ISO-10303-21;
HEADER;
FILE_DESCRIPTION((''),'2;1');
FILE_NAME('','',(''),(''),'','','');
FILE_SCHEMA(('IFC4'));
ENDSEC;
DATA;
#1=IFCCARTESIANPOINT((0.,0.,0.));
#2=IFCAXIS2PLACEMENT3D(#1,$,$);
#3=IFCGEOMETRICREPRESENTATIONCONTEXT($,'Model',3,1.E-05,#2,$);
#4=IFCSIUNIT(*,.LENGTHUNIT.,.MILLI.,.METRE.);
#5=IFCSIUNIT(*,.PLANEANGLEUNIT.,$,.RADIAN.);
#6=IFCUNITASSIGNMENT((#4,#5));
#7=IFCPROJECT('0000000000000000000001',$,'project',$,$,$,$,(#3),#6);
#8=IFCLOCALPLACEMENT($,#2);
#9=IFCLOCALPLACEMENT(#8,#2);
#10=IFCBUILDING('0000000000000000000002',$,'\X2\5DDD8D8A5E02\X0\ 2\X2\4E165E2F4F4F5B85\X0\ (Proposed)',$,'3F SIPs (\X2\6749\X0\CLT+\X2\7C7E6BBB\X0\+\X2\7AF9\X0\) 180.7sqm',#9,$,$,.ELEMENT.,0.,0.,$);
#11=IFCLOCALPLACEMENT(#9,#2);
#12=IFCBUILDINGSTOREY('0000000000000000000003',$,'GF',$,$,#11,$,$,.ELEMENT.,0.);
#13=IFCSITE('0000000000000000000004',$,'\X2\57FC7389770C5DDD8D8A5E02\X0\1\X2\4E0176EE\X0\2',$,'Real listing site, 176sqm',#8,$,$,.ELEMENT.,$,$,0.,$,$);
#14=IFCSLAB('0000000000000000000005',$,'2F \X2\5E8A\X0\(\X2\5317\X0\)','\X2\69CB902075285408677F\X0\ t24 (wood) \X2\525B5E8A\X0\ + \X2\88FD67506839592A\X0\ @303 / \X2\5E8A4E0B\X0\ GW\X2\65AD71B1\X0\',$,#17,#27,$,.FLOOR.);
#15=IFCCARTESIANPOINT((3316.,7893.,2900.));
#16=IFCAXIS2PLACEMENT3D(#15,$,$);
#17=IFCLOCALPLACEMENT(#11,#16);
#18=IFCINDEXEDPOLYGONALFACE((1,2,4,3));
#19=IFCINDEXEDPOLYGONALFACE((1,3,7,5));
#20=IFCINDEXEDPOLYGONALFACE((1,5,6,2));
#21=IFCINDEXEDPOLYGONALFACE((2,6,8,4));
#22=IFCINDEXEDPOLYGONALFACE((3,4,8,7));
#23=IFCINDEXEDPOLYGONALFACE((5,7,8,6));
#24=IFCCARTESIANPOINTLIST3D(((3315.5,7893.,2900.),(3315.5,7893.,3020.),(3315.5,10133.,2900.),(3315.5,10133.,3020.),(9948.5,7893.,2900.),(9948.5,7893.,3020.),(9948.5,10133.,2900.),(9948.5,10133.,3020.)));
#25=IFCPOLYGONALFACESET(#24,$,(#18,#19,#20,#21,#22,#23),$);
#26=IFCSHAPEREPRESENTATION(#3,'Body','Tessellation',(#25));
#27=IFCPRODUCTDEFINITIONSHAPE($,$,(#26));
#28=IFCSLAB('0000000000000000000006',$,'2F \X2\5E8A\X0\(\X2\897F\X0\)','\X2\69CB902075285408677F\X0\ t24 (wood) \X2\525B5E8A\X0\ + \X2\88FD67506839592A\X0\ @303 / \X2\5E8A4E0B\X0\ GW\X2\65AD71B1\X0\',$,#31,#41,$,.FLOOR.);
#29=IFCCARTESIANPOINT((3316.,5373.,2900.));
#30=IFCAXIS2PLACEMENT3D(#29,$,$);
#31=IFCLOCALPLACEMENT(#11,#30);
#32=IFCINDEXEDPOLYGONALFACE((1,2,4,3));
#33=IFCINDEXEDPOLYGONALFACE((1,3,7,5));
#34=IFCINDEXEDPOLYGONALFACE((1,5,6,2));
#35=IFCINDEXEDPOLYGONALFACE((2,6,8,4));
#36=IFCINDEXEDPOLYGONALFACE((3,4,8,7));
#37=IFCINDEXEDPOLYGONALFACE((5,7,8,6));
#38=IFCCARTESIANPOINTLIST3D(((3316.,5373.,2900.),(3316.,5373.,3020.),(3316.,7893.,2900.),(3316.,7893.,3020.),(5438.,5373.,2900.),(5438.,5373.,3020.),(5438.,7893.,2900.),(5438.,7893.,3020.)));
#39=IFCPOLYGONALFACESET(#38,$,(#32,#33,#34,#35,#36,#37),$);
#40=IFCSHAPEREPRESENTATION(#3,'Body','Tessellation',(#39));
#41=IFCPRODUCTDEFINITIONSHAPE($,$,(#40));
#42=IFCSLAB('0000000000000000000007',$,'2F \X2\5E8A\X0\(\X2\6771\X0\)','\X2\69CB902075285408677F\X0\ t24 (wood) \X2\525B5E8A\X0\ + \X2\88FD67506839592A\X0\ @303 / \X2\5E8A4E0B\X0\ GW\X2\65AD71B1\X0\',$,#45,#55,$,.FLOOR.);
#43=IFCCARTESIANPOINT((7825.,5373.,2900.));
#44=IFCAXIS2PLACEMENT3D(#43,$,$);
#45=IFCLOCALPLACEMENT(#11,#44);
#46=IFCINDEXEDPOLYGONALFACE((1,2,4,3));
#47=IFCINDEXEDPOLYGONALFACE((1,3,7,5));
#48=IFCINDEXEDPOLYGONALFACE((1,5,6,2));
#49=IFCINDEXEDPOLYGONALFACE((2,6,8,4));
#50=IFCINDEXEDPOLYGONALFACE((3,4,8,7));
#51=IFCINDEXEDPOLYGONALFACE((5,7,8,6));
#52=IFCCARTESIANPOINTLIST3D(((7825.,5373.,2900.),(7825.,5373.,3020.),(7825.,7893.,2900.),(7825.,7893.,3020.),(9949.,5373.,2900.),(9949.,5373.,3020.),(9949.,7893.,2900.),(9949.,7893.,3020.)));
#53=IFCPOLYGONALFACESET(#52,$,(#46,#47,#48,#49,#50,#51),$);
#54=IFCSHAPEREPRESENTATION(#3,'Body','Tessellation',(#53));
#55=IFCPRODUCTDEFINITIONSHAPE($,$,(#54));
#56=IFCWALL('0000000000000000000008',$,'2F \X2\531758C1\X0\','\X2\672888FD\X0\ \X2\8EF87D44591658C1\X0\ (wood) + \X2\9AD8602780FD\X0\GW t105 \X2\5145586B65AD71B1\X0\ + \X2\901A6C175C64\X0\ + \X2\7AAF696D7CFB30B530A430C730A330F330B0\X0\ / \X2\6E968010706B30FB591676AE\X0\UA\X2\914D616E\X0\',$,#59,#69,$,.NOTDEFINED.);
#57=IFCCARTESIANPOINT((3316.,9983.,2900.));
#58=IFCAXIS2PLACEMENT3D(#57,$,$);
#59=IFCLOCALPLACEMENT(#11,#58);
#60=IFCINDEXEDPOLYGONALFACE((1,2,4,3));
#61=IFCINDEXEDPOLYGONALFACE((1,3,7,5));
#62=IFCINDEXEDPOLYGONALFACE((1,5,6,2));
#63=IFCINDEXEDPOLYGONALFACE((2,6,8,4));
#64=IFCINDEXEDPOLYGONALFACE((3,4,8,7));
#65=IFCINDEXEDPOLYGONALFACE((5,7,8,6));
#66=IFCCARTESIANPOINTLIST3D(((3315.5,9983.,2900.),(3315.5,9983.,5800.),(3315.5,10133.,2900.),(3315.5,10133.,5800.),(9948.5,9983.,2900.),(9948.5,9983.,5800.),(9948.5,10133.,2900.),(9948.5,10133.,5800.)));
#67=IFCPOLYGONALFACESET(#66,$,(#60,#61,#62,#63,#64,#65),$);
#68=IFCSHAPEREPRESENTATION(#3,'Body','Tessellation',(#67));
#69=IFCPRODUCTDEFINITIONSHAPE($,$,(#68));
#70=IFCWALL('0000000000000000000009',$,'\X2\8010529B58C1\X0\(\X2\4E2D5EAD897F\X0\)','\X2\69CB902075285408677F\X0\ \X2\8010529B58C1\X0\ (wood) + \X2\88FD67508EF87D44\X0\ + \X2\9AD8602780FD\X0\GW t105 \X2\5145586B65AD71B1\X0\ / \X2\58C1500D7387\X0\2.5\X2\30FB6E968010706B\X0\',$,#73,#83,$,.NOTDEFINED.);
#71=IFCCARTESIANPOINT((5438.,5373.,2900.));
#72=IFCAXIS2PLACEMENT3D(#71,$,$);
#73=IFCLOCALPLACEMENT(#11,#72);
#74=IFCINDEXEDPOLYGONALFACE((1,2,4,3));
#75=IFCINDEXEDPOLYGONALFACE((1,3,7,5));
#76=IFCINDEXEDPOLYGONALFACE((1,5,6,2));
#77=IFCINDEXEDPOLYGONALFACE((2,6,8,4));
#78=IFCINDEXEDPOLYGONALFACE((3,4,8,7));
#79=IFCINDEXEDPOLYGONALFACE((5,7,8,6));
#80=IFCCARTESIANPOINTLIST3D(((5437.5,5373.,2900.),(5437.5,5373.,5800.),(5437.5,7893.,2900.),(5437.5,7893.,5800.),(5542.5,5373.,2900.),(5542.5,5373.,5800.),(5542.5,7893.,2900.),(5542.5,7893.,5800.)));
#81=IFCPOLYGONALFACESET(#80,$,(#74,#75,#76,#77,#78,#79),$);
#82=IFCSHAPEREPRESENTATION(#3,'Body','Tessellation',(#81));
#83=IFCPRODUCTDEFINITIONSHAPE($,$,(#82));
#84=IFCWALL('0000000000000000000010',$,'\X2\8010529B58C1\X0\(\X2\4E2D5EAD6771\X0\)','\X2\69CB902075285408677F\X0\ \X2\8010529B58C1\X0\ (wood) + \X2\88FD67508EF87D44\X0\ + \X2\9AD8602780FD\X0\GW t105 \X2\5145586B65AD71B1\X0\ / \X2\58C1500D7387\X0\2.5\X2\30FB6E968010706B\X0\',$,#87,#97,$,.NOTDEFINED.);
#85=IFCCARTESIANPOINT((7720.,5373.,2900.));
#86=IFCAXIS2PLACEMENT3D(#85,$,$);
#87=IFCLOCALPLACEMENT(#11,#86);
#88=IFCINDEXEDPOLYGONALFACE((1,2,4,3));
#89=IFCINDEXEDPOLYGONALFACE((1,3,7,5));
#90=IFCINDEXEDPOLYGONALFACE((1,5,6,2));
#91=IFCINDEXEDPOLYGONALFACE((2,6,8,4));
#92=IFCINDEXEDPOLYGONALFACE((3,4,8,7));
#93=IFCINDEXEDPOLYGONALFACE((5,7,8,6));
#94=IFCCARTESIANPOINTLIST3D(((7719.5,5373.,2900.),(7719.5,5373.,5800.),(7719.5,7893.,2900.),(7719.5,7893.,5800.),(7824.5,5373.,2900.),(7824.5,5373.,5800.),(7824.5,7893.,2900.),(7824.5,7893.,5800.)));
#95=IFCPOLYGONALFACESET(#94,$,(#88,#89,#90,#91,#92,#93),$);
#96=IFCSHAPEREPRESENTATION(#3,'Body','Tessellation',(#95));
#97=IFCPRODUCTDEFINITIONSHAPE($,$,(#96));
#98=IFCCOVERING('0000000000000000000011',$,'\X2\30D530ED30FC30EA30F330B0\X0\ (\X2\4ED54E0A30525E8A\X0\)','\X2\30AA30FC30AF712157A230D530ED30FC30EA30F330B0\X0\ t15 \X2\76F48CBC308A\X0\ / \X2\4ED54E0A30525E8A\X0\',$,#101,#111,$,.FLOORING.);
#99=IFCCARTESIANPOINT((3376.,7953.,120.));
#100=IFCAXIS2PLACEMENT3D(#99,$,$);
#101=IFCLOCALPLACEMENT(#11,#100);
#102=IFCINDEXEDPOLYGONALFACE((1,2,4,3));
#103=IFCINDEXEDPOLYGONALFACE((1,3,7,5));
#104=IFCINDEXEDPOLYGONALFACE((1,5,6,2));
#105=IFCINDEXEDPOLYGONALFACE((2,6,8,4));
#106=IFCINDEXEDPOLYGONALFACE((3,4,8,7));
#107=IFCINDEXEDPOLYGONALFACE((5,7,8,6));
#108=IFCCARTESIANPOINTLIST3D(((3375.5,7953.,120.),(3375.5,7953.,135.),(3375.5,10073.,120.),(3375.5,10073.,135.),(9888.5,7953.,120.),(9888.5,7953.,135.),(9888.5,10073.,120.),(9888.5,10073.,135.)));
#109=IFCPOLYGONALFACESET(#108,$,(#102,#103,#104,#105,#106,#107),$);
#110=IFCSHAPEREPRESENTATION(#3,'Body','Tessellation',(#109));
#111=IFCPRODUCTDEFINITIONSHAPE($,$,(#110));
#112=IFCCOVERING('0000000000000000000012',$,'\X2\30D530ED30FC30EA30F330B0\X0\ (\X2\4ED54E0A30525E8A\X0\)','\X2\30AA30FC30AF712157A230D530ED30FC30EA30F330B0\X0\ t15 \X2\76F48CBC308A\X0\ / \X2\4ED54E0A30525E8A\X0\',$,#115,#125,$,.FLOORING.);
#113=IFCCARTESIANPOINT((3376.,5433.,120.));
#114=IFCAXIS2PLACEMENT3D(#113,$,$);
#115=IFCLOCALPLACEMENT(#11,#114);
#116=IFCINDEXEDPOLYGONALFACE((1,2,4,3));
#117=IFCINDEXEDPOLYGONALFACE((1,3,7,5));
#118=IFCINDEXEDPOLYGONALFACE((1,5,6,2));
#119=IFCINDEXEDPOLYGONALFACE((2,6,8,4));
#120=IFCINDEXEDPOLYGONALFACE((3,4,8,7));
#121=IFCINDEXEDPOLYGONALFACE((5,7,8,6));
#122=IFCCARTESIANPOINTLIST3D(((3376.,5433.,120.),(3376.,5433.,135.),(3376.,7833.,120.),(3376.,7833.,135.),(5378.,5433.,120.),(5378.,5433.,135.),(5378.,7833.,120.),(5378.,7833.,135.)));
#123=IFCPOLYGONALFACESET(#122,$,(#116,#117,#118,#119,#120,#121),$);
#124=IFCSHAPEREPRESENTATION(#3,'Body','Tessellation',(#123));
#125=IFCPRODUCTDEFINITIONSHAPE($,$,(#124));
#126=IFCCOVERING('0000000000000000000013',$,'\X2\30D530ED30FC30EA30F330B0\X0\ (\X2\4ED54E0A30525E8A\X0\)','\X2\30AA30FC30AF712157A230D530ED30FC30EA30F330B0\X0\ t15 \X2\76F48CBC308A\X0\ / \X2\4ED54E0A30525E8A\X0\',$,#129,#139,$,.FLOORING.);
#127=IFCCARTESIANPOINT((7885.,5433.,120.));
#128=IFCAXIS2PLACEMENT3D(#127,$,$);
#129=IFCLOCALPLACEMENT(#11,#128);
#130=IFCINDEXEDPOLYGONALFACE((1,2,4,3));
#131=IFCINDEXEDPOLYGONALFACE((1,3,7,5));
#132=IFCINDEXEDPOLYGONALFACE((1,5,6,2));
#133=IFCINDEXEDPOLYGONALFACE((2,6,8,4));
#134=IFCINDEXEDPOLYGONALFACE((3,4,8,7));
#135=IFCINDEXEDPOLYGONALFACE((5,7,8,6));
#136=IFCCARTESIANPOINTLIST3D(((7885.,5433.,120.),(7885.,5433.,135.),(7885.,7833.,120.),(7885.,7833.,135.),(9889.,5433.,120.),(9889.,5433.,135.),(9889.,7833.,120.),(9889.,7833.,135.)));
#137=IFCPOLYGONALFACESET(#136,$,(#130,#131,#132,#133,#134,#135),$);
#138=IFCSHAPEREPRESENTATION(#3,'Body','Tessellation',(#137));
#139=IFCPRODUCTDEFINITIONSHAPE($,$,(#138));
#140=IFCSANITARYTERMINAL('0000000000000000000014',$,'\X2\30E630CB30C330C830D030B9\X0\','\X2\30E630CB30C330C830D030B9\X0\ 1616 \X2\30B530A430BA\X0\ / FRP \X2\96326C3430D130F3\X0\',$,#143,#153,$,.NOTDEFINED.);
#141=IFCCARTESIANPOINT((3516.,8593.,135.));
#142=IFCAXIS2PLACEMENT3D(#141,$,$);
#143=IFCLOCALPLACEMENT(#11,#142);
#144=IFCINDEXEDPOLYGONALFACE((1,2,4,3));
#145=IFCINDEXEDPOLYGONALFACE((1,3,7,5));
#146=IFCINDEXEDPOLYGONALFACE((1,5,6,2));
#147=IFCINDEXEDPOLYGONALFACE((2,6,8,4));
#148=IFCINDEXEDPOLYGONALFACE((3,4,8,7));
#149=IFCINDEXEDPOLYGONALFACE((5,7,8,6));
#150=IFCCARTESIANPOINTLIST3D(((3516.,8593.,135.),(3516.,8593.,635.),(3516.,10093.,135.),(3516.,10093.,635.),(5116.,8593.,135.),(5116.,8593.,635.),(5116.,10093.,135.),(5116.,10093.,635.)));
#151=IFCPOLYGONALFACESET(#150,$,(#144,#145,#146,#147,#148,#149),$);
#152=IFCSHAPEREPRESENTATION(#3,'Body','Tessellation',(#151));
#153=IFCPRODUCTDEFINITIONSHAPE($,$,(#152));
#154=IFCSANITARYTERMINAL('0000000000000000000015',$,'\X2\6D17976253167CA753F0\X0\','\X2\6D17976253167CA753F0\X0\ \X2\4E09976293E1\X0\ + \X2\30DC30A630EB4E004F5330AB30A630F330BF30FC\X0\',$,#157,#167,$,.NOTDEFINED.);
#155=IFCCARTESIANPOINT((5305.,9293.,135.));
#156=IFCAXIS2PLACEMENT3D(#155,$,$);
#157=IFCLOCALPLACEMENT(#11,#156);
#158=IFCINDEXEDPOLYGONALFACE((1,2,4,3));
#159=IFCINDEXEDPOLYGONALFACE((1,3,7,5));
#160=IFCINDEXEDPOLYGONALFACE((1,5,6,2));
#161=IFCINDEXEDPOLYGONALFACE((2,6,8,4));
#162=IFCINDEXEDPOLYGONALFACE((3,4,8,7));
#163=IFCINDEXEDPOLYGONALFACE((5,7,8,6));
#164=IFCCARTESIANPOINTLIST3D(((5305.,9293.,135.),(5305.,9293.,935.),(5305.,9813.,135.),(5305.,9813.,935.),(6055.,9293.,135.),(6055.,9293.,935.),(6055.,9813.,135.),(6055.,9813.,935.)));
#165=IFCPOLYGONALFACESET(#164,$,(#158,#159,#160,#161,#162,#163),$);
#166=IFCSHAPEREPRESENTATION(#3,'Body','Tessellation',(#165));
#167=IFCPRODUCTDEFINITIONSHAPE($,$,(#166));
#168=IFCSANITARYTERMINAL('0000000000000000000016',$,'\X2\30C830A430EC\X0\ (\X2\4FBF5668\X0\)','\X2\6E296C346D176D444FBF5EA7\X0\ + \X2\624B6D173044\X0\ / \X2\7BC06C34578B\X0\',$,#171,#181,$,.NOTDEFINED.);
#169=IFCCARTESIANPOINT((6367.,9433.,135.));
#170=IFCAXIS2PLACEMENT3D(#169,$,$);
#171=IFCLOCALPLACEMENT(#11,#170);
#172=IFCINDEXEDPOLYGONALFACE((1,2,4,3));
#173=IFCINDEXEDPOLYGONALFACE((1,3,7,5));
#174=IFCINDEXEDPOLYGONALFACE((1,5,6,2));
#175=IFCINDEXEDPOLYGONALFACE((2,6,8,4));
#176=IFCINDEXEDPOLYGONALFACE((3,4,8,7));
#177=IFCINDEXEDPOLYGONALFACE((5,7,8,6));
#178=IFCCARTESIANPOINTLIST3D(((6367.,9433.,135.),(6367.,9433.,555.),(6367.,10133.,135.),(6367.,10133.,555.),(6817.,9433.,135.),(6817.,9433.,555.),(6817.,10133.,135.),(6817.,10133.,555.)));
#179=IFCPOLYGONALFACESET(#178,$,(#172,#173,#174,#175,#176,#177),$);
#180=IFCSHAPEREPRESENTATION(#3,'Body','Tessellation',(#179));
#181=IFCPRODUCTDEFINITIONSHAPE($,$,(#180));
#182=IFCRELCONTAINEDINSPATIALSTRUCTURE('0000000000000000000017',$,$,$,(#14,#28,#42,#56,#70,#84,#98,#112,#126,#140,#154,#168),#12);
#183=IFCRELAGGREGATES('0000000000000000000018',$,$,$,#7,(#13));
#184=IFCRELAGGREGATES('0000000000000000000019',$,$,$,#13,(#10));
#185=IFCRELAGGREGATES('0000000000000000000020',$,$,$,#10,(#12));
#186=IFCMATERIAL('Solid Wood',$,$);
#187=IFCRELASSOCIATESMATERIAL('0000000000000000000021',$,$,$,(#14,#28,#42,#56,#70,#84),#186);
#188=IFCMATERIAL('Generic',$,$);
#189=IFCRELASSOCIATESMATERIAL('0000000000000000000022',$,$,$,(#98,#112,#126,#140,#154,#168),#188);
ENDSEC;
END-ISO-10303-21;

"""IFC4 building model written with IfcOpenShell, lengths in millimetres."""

from ifc_helpers import new_model, si_unit, frame, frame_2d, origin, place, context, project, spatial, rectangle, extrude, material, element, save


model = new_model("IFC4")

# Units and contexts
model_context = context("Model", 3, precision=1e-05, world=origin())
ifc_project = project(units=[si_unit("LENGTHUNIT", "METRE", prefix="MILLI"), si_unit("PLANEANGLEUNIT", "RADIAN")], contexts=[model_context])

# Site, building, storey
site_placement = place(None, origin())
site = spatial("IfcSite", under=ifc_project, at=site_placement, Name="埼玉県川越市1丁目2", ObjectType="Real listing site, 176sqm", CompositionType="ELEMENT", RefElevation=0.0)
building_placement = place(site_placement, origin())
building = spatial("IfcBuilding", under=site, at=building_placement, Name="川越市 2世帯住宅 (Proposed)", ObjectType="3F SIPs (杉CLT+籾殻+竹) 180.7sqm", CompositionType="ELEMENT", ElevationOfRefHeight=0.0, ElevationOfTerrain=0.0)
storey_placement = place(building_placement, origin())
storey = spatial("IfcBuildingStorey", under=building, at=storey_placement, Name="GF", CompositionType="ELEMENT", Elevation=0.0)

# Slabs
ifc_material_1 = material(Name="Solid Wood")
slab_1_placement = place(storey_placement, frame((3316.0, 7893.0, 2900.0)))
element("IfcSlab", 1, at=slab_1_placement, inside=storey, material=ifc_material_1, Name="2F 床(北)", Description="構造用合板 t24 (wood) 剛床 + 製材根太 @303 / 床下 GW断熱", PredefinedType="FLOOR", context=model_context, shape_type="SweptSolid", body=[
    extrude(rectangle(XDim=6633.0, YDim=2240.0, at=frame_2d((3316.0, 1120.0))), frame((3316.0, 7893.0, 2900.0)), (0.0, 0.0, 1.0), 120.0),
])
slab_2_placement = place(storey_placement, frame((3316.0, 5373.0, 2900.0)))
element("IfcSlab", 2, at=slab_2_placement, inside=storey, material=ifc_material_1, Name="2F 床(西)", Description="構造用合板 t24 (wood) 剛床 + 製材根太 @303 / 床下 GW断熱", PredefinedType="FLOOR", context=model_context, shape_type="SweptSolid", body=[
    extrude(rectangle(XDim=2122.0, YDim=2520.0, at=frame_2d((1061.0, 1260.0))), frame((3316.0, 5373.0, 2900.0)), (0.0, 0.0, 1.0), 120.0),
])
slab_3_placement = place(storey_placement, frame((7825.0, 5373.0, 2900.0)))
element("IfcSlab", 3, at=slab_3_placement, inside=storey, material=ifc_material_1, Name="2F 床(東)", Description="構造用合板 t24 (wood) 剛床 + 製材根太 @303 / 床下 GW断熱", PredefinedType="FLOOR", context=model_context, shape_type="SweptSolid", body=[
    extrude(rectangle(XDim=2124.0, YDim=2520.0, at=frame_2d((1062.0, 1260.0))), frame((7825.0, 5373.0, 2900.0)), (0.0, 0.0, 1.0), 120.0),
])

# Wall
wall_1_placement = place(storey_placement, frame((3316.0, 9983.0, 2900.0)))
element("IfcWall", 4, at=wall_1_placement, inside=storey, material=ifc_material_1, Name="2F 北壁", Description="木製 軸組外壁 (wood) + 高性能GW t105 充填断熱 + 通気層 + 窯業系サイディング / 準耐火・外皮UA配慮", PredefinedType="NOTDEFINED", context=model_context, shape_type="SweptSolid", body=[
    extrude(rectangle(XDim=6633.0, YDim=150.0, at=frame_2d((3316.0, 75.0))), frame((3316.0, 9983.0, 2900.0)), (0.0, 0.0, 1.0), 2900.0),
])

# Walls
wall_2_placement = place(storey_placement, frame((5438.0, 5373.0, 2900.0)))
element("IfcWall", 5, at=wall_2_placement, inside=storey, material=ifc_material_1, Name="耐力壁(中庭西)", Description="構造用合板 耐力壁 (wood) + 製材軸組 + 高性能GW t105 充填断熱 / 壁倍率2.5・準耐火", PredefinedType="NOTDEFINED", context=model_context, shape_type="SweptSolid", body=[
    extrude(rectangle(XDim=105.0, YDim=2520.0, at=frame_2d((52.0, 1260.0))), frame((5438.0, 5373.0, 2900.0)), (0.0, 0.0, 1.0), 2900.0),
])
wall_3_placement = place(storey_placement, frame((7720.0, 5373.0, 2900.0)))
element("IfcWall", 6, at=wall_3_placement, inside=storey, material=ifc_material_1, Name="耐力壁(中庭東)", Description="構造用合板 耐力壁 (wood) + 製材軸組 + 高性能GW t105 充填断熱 / 壁倍率2.5・準耐火", PredefinedType="NOTDEFINED", context=model_context, shape_type="SweptSolid", body=[
    extrude(rectangle(XDim=105.0, YDim=2520.0, at=frame_2d((52.0, 1260.0))), frame((7720.0, 5373.0, 2900.0)), (0.0, 0.0, 1.0), 2900.0),
])

# Coverings
ifc_material_2 = material(Name="Generic")
covering_1_placement = place(storey_placement, frame((3376.0, 7953.0, 120.0)))
element("IfcCovering", 7, at=covering_1_placement, inside=storey, material=ifc_material_2, Name="フローリング (仕上げ床)", Description="オーク無垢フローリング t15 直貼り / 仕上げ床", PredefinedType="FLOORING", context=model_context, shape_type="SweptSolid", body=[
    extrude(rectangle(XDim=6513.0, YDim=2120.0, at=frame_2d((3256.0, 1060.0))), frame((3376.0, 7953.0, 120.0)), (0.0, 0.0, 1.0), 15.0),
])
covering_2_placement = place(storey_placement, frame((3376.0, 5433.0, 120.0)))
element("IfcCovering", 8, at=covering_2_placement, inside=storey, material=ifc_material_2, Name="フローリング (仕上げ床)", Description="オーク無垢フローリング t15 直貼り / 仕上げ床", PredefinedType="FLOORING", context=model_context, shape_type="SweptSolid", body=[
    extrude(rectangle(XDim=2002.0, YDim=2400.0, at=frame_2d((1001.0, 1200.0))), frame((3376.0, 5433.0, 120.0)), (0.0, 0.0, 1.0), 15.0),
])
covering_3_placement = place(storey_placement, frame((7885.0, 5433.0, 120.0)))
element("IfcCovering", 9, at=covering_3_placement, inside=storey, material=ifc_material_2, Name="フローリング (仕上げ床)", Description="オーク無垢フローリング t15 直貼り / 仕上げ床", PredefinedType="FLOORING", context=model_context, shape_type="SweptSolid", body=[
    extrude(rectangle(XDim=2004.0, YDim=2400.0, at=frame_2d((1002.0, 1200.0))), frame((7885.0, 5433.0, 120.0)), (0.0, 0.0, 1.0), 15.0),
])

# Sanitary terminals
sanitary_terminal_1_placement = place(storey_placement, frame((3516.0, 8593.0, 135.0)))
element("IfcSanitaryTerminal", 10, at=sanitary_terminal_1_placement, inside=storey, material=ifc_material_2, Name="ユニットバス", Description="ユニットバス 1616 サイズ / FRP 防水パン", PredefinedType="NOTDEFINED", context=model_context, shape_type="SweptSolid", body=[
    extrude(rectangle(XDim=1600.0, YDim=1500.0, at=frame_2d((800.0, 750.0))), frame((3516.0, 8593.0, 135.0)), (0.0, 0.0, 1.0), 500.0),
])
sanitary_terminal_2_placement = place(storey_placement, frame((5305.0, 9293.0, 135.0)))
element("IfcSanitaryTerminal", 11, at=sanitary_terminal_2_placement, inside=storey, material=ifc_material_2, Name="洗面化粧台", Description="洗面化粧台 三面鏡 + ボウル一体カウンター", PredefinedType="NOTDEFINED", context=model_context, shape_type="SweptSolid", body=[
    extrude(rectangle(XDim=750.0, YDim=520.0, at=frame_2d((375.0, 260.0))), frame((5305.0, 9293.0, 135.0)), (0.0, 0.0, 1.0), 800.0),
])
sanitary_terminal_3_placement = place(storey_placement, frame((6367.0, 9433.0, 135.0)))
element("IfcSanitaryTerminal", 12, at=sanitary_terminal_3_placement, inside=storey, material=ifc_material_2, Name="トイレ (便器)", Description="温水洗浄便座 + 手洗い / 節水型", PredefinedType="NOTDEFINED", context=model_context, shape_type="SweptSolid", body=[
    extrude(rectangle(XDim=450.0, YDim=700.0, at=frame_2d((225.0, 350.0))), frame((6367.0, 9433.0, 135.0)), (0.0, 0.0, 1.0), 420.0),
])

save(model, "model.ifc")
